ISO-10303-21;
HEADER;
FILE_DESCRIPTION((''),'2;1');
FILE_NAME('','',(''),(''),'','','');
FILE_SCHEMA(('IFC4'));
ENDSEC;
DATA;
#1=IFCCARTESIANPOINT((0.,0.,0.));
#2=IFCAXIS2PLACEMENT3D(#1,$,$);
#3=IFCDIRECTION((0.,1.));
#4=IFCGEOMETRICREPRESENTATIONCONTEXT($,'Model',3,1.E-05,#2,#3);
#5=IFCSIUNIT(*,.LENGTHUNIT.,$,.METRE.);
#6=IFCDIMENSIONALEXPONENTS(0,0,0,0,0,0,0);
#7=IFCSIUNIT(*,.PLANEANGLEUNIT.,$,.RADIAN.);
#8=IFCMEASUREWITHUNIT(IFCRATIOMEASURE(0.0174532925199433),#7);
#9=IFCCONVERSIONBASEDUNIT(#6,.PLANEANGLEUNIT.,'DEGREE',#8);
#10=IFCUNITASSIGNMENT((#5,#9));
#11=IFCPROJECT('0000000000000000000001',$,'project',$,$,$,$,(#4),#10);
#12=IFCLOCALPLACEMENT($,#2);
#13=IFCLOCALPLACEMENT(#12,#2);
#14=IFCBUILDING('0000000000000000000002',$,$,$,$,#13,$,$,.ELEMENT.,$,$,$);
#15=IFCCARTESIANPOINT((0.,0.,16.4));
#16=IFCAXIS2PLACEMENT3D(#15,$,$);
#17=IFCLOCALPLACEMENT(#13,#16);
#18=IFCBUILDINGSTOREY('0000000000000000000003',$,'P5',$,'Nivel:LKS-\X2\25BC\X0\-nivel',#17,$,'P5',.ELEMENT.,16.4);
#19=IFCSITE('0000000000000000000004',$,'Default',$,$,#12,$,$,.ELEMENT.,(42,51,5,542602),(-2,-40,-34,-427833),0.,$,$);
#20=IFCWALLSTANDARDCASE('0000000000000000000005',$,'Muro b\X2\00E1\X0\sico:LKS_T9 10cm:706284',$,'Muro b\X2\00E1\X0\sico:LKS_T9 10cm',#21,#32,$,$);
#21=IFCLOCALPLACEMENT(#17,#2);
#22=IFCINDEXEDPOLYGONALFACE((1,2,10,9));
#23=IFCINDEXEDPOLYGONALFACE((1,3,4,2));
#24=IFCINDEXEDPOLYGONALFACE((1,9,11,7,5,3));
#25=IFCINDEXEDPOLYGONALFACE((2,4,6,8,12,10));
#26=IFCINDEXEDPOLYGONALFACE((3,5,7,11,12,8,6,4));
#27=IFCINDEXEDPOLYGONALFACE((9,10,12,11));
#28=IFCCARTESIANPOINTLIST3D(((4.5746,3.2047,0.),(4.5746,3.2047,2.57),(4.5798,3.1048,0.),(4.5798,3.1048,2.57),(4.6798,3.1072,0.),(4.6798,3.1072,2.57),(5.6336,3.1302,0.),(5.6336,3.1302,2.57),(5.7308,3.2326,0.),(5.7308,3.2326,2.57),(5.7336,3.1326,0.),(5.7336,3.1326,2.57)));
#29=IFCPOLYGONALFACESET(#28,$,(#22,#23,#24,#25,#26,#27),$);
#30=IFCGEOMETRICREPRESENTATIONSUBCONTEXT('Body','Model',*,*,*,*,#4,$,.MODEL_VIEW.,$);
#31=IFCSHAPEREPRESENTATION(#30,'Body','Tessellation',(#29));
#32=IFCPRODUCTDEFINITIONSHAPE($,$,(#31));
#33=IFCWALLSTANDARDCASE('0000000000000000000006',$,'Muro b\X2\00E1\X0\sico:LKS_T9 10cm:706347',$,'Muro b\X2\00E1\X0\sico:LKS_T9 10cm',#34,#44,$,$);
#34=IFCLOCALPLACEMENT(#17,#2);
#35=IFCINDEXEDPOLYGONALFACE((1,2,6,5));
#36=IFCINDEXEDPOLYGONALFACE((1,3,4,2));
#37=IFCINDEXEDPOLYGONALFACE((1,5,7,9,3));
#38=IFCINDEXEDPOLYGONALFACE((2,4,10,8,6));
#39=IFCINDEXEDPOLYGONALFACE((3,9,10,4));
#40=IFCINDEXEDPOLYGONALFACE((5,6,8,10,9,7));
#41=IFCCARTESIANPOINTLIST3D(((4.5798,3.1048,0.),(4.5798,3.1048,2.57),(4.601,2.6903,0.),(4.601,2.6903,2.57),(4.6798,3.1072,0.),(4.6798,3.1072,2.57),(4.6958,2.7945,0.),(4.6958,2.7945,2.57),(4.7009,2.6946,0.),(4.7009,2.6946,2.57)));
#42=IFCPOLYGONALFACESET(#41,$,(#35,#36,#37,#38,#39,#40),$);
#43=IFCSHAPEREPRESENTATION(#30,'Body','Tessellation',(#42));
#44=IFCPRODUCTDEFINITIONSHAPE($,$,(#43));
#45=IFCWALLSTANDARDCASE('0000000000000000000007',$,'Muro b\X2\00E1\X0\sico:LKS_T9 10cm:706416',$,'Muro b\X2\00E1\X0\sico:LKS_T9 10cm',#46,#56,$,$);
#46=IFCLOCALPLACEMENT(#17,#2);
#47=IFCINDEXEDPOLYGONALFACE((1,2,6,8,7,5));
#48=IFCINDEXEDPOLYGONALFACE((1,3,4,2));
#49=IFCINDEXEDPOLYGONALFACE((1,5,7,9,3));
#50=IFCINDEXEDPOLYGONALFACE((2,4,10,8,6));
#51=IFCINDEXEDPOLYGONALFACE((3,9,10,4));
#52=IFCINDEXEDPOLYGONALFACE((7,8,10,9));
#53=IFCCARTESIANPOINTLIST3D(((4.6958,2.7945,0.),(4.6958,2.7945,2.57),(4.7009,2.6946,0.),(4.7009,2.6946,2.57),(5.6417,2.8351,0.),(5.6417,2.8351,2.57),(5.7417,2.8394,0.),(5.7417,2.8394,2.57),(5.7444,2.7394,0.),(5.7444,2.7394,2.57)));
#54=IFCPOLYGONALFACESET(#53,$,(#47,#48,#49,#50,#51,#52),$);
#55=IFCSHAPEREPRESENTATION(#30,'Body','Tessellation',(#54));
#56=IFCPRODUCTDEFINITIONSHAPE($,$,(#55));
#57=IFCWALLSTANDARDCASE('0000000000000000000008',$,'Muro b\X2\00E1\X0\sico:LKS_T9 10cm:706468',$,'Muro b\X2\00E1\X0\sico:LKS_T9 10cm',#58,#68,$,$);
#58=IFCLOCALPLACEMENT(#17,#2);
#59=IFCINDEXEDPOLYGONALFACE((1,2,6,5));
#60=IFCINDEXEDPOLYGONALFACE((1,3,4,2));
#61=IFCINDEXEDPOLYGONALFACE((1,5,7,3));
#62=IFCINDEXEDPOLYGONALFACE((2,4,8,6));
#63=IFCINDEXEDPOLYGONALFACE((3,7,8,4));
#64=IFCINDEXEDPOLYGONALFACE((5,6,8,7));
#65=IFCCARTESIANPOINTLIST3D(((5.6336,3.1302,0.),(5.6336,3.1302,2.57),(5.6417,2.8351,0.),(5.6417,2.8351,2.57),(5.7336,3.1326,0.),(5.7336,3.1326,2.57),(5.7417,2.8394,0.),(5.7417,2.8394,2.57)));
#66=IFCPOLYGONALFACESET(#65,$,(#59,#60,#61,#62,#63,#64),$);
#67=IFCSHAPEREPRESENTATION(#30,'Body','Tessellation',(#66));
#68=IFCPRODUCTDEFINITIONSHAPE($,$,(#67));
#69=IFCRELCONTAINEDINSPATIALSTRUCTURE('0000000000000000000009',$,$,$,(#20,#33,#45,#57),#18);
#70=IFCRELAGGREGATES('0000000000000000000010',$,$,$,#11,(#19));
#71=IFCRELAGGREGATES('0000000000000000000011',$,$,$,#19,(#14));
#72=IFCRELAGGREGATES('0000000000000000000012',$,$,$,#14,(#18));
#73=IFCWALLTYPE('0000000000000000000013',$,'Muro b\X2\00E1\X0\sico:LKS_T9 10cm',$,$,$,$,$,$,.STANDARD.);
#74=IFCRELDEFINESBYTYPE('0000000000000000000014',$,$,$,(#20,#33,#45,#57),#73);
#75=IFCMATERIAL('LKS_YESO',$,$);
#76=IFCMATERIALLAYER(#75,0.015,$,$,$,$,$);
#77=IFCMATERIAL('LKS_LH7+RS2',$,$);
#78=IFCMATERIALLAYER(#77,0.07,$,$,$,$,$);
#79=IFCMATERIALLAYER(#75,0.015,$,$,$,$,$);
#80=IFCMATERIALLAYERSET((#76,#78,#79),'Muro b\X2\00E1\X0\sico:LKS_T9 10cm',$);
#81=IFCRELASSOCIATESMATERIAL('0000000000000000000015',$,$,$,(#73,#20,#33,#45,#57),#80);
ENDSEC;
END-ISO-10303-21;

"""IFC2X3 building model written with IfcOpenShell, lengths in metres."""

from ifc_helpers import new_model, entity, si_unit, converted_unit, direction, frame, origin, place, context, subcontext, project, spatial, polyline, outline, extrude, material, layer, layer_set, layer_usage, type_object, element, save


model = new_model("IFC2X3")

# Units and contexts
model_context = context("Model", 3, precision=1e-05, world=origin(), true_north=direction((0.0, 1.0)))
body_context = subcontext(model_context, "Body", "Model", "MODEL_VIEW")
ifc_project = project(units=[si_unit("LENGTHUNIT", "METRE"), converted_unit("PLANEANGLEUNIT", "DEGREE", entity("IfcRatioMeasure", 0.0174532925199433), si_unit("PLANEANGLEUNIT", "RADIAN"), dimensions=[0, 0, 0, 0, 0, 0, 0])], contexts=[model_context])

# Site, building, storey
site_placement = place(None, origin())
site = spatial("IfcSite", under=ifc_project, at=site_placement, Name="Default", CompositionType="ELEMENT", RefLatitude=(42, 51, 5, 542602), RefLongitude=(-2, -40, -34, -427833), RefElevation=0.0)
building_placement = place(site_placement, origin())
building = spatial("IfcBuilding", under=site, at=building_placement, CompositionType="ELEMENT")
storey_placement = place(building_placement, frame((0.0, 0.0, 16.4)))
storey = spatial("IfcBuildingStorey", under=building, at=storey_placement, Name="P5", ObjectType="Nivel:LKS-▼-nivel", LongName="P5", CompositionType="ELEMENT", Elevation=16.4)

# Walls
ifc_material_1 = material(Name="LKS_YESO")
ifc_layer_1 = layer(ifc_material_1, 0.015)
ifc_material_2 = material(Name="LKS_LH7+RS2")
ifc_layer_2 = layer(ifc_material_2, 0.07)
ifc_layer_3 = layer(ifc_material_1, 0.015)
ifc_layer_set_1 = layer_set([ifc_layer_1, ifc_layer_2, ifc_layer_3], Name="Muro básico:LKS_T9 10cm")
wall_type_1 = type_object("IfcWallType", Name="Muro básico:LKS_T9 10cm", PredefinedType="STANDARD", material=ifc_layer_set_1)
ifc_layer_usage_1 = layer_usage(ifc_layer_set_1, "AXIS2", "POSITIVE", -0.05)
wall_1_placement = place(storey_placement, frame((5.7324, 3.1826, 0.0), z_axis=(0.0, 0.0, 1.0), x_axis=(-0.999709, -0.024134, 0.0)))
element("IfcWallStandardCase", 1, at=wall_1_placement, inside=storey, type_object=wall_type_1, material=ifc_layer_usage_1, Name="Muro básico:LKS_T9 10cm:706284", ObjectType="Muro básico:LKS_T9 10cm", context=body_context, shape_type="SweptSolid", body=[
    extrude(outline(polyline([(1.1569, -0.05), (1.1542, 0.05), (1.0541, 0.05), (0.1, 0.05), (0.0, 0.05), (0.0003, -0.05), (1.1569, -0.05)])), origin(), (0.0, 0.0, 1.0), 2.57),
])
ifc_layer_usage_2 = layer_usage(ifc_layer_set_1, "AXIS2", "POSITIVE", -0.05)
wall_2_placement = place(storey_placement, frame((4.6297, 3.1073, 0.0), z_axis=(0.0, 0.0, 1.0), x_axis=(0.051246, -0.998686, 0.0)))
element("IfcWallStandardCase", 2, at=wall_2_placement, inside=storey, type_object=wall_type_1, material=ifc_layer_usage_2, Name="Muro básico:LKS_T9 10cm:706347", ObjectType="Muro básico:LKS_T9 10cm", context=body_context, shape_type="SweptSolid", body=[
    extrude(outline(polyline([(0.415, -0.05), (0.4158, 0.05), (0.3158, 0.05), (0.0027, 0.05), (0.0, -0.05), (0.415, -0.05)])), origin(), (0.0, 0.0, 1.0), 2.57),
])
ifc_layer_usage_3 = layer_usage(ifc_layer_set_1, "AXIS2", "POSITIVE", -0.05)
wall_3_placement = place(storey_placement, frame((4.698, 2.7445, 0.0), z_axis=(0.0, 0.0, 1.0), x_axis=(0.99908, 0.042893, 0.0)))
element("IfcWallStandardCase", 3, at=wall_3_placement, inside=storey, type_object=wall_type_1, material=ifc_layer_usage_3, Name="Muro básico:LKS_T9 10cm:706416", ObjectType="Muro básico:LKS_T9 10cm", context=body_context, shape_type="SweptSolid", body=[
    extrude(outline(polyline([(1.0453, -0.05), (1.0468, 0.05), (0.9468, 0.05), (0.0, 0.05), (0.0008, -0.05), (1.0453, -0.05)])), origin(), (0.0, 0.0, 1.0), 2.57),
])
ifc_layer_usage_4 = layer_usage(ifc_layer_set_1, "AXIS2", "POSITIVE", -0.05)
wall_4_placement = place(storey_placement, frame((5.6917, 2.8365, 0.0), z_axis=(0.0, 0.0, 1.0), x_axis=(-0.027495, 0.999622, 0.0)))
element("IfcWallStandardCase", 4, at=wall_4_placement, inside=storey, type_object=wall_type_1, material=ifc_layer_usage_4, Name="Muro básico:LKS_T9 10cm:706468", ObjectType="Muro básico:LKS_T9 10cm", context=body_context, shape_type="SweptSolid", body=[
    extrude(outline(polyline([(0.2949, -0.05), (0.2952, 0.05), (0.0, 0.05), (0.0015, -0.05), (0.2949, -0.05)])), origin(), (0.0, 0.0, 1.0), 2.57),
])

save(model, "model.ifc")
